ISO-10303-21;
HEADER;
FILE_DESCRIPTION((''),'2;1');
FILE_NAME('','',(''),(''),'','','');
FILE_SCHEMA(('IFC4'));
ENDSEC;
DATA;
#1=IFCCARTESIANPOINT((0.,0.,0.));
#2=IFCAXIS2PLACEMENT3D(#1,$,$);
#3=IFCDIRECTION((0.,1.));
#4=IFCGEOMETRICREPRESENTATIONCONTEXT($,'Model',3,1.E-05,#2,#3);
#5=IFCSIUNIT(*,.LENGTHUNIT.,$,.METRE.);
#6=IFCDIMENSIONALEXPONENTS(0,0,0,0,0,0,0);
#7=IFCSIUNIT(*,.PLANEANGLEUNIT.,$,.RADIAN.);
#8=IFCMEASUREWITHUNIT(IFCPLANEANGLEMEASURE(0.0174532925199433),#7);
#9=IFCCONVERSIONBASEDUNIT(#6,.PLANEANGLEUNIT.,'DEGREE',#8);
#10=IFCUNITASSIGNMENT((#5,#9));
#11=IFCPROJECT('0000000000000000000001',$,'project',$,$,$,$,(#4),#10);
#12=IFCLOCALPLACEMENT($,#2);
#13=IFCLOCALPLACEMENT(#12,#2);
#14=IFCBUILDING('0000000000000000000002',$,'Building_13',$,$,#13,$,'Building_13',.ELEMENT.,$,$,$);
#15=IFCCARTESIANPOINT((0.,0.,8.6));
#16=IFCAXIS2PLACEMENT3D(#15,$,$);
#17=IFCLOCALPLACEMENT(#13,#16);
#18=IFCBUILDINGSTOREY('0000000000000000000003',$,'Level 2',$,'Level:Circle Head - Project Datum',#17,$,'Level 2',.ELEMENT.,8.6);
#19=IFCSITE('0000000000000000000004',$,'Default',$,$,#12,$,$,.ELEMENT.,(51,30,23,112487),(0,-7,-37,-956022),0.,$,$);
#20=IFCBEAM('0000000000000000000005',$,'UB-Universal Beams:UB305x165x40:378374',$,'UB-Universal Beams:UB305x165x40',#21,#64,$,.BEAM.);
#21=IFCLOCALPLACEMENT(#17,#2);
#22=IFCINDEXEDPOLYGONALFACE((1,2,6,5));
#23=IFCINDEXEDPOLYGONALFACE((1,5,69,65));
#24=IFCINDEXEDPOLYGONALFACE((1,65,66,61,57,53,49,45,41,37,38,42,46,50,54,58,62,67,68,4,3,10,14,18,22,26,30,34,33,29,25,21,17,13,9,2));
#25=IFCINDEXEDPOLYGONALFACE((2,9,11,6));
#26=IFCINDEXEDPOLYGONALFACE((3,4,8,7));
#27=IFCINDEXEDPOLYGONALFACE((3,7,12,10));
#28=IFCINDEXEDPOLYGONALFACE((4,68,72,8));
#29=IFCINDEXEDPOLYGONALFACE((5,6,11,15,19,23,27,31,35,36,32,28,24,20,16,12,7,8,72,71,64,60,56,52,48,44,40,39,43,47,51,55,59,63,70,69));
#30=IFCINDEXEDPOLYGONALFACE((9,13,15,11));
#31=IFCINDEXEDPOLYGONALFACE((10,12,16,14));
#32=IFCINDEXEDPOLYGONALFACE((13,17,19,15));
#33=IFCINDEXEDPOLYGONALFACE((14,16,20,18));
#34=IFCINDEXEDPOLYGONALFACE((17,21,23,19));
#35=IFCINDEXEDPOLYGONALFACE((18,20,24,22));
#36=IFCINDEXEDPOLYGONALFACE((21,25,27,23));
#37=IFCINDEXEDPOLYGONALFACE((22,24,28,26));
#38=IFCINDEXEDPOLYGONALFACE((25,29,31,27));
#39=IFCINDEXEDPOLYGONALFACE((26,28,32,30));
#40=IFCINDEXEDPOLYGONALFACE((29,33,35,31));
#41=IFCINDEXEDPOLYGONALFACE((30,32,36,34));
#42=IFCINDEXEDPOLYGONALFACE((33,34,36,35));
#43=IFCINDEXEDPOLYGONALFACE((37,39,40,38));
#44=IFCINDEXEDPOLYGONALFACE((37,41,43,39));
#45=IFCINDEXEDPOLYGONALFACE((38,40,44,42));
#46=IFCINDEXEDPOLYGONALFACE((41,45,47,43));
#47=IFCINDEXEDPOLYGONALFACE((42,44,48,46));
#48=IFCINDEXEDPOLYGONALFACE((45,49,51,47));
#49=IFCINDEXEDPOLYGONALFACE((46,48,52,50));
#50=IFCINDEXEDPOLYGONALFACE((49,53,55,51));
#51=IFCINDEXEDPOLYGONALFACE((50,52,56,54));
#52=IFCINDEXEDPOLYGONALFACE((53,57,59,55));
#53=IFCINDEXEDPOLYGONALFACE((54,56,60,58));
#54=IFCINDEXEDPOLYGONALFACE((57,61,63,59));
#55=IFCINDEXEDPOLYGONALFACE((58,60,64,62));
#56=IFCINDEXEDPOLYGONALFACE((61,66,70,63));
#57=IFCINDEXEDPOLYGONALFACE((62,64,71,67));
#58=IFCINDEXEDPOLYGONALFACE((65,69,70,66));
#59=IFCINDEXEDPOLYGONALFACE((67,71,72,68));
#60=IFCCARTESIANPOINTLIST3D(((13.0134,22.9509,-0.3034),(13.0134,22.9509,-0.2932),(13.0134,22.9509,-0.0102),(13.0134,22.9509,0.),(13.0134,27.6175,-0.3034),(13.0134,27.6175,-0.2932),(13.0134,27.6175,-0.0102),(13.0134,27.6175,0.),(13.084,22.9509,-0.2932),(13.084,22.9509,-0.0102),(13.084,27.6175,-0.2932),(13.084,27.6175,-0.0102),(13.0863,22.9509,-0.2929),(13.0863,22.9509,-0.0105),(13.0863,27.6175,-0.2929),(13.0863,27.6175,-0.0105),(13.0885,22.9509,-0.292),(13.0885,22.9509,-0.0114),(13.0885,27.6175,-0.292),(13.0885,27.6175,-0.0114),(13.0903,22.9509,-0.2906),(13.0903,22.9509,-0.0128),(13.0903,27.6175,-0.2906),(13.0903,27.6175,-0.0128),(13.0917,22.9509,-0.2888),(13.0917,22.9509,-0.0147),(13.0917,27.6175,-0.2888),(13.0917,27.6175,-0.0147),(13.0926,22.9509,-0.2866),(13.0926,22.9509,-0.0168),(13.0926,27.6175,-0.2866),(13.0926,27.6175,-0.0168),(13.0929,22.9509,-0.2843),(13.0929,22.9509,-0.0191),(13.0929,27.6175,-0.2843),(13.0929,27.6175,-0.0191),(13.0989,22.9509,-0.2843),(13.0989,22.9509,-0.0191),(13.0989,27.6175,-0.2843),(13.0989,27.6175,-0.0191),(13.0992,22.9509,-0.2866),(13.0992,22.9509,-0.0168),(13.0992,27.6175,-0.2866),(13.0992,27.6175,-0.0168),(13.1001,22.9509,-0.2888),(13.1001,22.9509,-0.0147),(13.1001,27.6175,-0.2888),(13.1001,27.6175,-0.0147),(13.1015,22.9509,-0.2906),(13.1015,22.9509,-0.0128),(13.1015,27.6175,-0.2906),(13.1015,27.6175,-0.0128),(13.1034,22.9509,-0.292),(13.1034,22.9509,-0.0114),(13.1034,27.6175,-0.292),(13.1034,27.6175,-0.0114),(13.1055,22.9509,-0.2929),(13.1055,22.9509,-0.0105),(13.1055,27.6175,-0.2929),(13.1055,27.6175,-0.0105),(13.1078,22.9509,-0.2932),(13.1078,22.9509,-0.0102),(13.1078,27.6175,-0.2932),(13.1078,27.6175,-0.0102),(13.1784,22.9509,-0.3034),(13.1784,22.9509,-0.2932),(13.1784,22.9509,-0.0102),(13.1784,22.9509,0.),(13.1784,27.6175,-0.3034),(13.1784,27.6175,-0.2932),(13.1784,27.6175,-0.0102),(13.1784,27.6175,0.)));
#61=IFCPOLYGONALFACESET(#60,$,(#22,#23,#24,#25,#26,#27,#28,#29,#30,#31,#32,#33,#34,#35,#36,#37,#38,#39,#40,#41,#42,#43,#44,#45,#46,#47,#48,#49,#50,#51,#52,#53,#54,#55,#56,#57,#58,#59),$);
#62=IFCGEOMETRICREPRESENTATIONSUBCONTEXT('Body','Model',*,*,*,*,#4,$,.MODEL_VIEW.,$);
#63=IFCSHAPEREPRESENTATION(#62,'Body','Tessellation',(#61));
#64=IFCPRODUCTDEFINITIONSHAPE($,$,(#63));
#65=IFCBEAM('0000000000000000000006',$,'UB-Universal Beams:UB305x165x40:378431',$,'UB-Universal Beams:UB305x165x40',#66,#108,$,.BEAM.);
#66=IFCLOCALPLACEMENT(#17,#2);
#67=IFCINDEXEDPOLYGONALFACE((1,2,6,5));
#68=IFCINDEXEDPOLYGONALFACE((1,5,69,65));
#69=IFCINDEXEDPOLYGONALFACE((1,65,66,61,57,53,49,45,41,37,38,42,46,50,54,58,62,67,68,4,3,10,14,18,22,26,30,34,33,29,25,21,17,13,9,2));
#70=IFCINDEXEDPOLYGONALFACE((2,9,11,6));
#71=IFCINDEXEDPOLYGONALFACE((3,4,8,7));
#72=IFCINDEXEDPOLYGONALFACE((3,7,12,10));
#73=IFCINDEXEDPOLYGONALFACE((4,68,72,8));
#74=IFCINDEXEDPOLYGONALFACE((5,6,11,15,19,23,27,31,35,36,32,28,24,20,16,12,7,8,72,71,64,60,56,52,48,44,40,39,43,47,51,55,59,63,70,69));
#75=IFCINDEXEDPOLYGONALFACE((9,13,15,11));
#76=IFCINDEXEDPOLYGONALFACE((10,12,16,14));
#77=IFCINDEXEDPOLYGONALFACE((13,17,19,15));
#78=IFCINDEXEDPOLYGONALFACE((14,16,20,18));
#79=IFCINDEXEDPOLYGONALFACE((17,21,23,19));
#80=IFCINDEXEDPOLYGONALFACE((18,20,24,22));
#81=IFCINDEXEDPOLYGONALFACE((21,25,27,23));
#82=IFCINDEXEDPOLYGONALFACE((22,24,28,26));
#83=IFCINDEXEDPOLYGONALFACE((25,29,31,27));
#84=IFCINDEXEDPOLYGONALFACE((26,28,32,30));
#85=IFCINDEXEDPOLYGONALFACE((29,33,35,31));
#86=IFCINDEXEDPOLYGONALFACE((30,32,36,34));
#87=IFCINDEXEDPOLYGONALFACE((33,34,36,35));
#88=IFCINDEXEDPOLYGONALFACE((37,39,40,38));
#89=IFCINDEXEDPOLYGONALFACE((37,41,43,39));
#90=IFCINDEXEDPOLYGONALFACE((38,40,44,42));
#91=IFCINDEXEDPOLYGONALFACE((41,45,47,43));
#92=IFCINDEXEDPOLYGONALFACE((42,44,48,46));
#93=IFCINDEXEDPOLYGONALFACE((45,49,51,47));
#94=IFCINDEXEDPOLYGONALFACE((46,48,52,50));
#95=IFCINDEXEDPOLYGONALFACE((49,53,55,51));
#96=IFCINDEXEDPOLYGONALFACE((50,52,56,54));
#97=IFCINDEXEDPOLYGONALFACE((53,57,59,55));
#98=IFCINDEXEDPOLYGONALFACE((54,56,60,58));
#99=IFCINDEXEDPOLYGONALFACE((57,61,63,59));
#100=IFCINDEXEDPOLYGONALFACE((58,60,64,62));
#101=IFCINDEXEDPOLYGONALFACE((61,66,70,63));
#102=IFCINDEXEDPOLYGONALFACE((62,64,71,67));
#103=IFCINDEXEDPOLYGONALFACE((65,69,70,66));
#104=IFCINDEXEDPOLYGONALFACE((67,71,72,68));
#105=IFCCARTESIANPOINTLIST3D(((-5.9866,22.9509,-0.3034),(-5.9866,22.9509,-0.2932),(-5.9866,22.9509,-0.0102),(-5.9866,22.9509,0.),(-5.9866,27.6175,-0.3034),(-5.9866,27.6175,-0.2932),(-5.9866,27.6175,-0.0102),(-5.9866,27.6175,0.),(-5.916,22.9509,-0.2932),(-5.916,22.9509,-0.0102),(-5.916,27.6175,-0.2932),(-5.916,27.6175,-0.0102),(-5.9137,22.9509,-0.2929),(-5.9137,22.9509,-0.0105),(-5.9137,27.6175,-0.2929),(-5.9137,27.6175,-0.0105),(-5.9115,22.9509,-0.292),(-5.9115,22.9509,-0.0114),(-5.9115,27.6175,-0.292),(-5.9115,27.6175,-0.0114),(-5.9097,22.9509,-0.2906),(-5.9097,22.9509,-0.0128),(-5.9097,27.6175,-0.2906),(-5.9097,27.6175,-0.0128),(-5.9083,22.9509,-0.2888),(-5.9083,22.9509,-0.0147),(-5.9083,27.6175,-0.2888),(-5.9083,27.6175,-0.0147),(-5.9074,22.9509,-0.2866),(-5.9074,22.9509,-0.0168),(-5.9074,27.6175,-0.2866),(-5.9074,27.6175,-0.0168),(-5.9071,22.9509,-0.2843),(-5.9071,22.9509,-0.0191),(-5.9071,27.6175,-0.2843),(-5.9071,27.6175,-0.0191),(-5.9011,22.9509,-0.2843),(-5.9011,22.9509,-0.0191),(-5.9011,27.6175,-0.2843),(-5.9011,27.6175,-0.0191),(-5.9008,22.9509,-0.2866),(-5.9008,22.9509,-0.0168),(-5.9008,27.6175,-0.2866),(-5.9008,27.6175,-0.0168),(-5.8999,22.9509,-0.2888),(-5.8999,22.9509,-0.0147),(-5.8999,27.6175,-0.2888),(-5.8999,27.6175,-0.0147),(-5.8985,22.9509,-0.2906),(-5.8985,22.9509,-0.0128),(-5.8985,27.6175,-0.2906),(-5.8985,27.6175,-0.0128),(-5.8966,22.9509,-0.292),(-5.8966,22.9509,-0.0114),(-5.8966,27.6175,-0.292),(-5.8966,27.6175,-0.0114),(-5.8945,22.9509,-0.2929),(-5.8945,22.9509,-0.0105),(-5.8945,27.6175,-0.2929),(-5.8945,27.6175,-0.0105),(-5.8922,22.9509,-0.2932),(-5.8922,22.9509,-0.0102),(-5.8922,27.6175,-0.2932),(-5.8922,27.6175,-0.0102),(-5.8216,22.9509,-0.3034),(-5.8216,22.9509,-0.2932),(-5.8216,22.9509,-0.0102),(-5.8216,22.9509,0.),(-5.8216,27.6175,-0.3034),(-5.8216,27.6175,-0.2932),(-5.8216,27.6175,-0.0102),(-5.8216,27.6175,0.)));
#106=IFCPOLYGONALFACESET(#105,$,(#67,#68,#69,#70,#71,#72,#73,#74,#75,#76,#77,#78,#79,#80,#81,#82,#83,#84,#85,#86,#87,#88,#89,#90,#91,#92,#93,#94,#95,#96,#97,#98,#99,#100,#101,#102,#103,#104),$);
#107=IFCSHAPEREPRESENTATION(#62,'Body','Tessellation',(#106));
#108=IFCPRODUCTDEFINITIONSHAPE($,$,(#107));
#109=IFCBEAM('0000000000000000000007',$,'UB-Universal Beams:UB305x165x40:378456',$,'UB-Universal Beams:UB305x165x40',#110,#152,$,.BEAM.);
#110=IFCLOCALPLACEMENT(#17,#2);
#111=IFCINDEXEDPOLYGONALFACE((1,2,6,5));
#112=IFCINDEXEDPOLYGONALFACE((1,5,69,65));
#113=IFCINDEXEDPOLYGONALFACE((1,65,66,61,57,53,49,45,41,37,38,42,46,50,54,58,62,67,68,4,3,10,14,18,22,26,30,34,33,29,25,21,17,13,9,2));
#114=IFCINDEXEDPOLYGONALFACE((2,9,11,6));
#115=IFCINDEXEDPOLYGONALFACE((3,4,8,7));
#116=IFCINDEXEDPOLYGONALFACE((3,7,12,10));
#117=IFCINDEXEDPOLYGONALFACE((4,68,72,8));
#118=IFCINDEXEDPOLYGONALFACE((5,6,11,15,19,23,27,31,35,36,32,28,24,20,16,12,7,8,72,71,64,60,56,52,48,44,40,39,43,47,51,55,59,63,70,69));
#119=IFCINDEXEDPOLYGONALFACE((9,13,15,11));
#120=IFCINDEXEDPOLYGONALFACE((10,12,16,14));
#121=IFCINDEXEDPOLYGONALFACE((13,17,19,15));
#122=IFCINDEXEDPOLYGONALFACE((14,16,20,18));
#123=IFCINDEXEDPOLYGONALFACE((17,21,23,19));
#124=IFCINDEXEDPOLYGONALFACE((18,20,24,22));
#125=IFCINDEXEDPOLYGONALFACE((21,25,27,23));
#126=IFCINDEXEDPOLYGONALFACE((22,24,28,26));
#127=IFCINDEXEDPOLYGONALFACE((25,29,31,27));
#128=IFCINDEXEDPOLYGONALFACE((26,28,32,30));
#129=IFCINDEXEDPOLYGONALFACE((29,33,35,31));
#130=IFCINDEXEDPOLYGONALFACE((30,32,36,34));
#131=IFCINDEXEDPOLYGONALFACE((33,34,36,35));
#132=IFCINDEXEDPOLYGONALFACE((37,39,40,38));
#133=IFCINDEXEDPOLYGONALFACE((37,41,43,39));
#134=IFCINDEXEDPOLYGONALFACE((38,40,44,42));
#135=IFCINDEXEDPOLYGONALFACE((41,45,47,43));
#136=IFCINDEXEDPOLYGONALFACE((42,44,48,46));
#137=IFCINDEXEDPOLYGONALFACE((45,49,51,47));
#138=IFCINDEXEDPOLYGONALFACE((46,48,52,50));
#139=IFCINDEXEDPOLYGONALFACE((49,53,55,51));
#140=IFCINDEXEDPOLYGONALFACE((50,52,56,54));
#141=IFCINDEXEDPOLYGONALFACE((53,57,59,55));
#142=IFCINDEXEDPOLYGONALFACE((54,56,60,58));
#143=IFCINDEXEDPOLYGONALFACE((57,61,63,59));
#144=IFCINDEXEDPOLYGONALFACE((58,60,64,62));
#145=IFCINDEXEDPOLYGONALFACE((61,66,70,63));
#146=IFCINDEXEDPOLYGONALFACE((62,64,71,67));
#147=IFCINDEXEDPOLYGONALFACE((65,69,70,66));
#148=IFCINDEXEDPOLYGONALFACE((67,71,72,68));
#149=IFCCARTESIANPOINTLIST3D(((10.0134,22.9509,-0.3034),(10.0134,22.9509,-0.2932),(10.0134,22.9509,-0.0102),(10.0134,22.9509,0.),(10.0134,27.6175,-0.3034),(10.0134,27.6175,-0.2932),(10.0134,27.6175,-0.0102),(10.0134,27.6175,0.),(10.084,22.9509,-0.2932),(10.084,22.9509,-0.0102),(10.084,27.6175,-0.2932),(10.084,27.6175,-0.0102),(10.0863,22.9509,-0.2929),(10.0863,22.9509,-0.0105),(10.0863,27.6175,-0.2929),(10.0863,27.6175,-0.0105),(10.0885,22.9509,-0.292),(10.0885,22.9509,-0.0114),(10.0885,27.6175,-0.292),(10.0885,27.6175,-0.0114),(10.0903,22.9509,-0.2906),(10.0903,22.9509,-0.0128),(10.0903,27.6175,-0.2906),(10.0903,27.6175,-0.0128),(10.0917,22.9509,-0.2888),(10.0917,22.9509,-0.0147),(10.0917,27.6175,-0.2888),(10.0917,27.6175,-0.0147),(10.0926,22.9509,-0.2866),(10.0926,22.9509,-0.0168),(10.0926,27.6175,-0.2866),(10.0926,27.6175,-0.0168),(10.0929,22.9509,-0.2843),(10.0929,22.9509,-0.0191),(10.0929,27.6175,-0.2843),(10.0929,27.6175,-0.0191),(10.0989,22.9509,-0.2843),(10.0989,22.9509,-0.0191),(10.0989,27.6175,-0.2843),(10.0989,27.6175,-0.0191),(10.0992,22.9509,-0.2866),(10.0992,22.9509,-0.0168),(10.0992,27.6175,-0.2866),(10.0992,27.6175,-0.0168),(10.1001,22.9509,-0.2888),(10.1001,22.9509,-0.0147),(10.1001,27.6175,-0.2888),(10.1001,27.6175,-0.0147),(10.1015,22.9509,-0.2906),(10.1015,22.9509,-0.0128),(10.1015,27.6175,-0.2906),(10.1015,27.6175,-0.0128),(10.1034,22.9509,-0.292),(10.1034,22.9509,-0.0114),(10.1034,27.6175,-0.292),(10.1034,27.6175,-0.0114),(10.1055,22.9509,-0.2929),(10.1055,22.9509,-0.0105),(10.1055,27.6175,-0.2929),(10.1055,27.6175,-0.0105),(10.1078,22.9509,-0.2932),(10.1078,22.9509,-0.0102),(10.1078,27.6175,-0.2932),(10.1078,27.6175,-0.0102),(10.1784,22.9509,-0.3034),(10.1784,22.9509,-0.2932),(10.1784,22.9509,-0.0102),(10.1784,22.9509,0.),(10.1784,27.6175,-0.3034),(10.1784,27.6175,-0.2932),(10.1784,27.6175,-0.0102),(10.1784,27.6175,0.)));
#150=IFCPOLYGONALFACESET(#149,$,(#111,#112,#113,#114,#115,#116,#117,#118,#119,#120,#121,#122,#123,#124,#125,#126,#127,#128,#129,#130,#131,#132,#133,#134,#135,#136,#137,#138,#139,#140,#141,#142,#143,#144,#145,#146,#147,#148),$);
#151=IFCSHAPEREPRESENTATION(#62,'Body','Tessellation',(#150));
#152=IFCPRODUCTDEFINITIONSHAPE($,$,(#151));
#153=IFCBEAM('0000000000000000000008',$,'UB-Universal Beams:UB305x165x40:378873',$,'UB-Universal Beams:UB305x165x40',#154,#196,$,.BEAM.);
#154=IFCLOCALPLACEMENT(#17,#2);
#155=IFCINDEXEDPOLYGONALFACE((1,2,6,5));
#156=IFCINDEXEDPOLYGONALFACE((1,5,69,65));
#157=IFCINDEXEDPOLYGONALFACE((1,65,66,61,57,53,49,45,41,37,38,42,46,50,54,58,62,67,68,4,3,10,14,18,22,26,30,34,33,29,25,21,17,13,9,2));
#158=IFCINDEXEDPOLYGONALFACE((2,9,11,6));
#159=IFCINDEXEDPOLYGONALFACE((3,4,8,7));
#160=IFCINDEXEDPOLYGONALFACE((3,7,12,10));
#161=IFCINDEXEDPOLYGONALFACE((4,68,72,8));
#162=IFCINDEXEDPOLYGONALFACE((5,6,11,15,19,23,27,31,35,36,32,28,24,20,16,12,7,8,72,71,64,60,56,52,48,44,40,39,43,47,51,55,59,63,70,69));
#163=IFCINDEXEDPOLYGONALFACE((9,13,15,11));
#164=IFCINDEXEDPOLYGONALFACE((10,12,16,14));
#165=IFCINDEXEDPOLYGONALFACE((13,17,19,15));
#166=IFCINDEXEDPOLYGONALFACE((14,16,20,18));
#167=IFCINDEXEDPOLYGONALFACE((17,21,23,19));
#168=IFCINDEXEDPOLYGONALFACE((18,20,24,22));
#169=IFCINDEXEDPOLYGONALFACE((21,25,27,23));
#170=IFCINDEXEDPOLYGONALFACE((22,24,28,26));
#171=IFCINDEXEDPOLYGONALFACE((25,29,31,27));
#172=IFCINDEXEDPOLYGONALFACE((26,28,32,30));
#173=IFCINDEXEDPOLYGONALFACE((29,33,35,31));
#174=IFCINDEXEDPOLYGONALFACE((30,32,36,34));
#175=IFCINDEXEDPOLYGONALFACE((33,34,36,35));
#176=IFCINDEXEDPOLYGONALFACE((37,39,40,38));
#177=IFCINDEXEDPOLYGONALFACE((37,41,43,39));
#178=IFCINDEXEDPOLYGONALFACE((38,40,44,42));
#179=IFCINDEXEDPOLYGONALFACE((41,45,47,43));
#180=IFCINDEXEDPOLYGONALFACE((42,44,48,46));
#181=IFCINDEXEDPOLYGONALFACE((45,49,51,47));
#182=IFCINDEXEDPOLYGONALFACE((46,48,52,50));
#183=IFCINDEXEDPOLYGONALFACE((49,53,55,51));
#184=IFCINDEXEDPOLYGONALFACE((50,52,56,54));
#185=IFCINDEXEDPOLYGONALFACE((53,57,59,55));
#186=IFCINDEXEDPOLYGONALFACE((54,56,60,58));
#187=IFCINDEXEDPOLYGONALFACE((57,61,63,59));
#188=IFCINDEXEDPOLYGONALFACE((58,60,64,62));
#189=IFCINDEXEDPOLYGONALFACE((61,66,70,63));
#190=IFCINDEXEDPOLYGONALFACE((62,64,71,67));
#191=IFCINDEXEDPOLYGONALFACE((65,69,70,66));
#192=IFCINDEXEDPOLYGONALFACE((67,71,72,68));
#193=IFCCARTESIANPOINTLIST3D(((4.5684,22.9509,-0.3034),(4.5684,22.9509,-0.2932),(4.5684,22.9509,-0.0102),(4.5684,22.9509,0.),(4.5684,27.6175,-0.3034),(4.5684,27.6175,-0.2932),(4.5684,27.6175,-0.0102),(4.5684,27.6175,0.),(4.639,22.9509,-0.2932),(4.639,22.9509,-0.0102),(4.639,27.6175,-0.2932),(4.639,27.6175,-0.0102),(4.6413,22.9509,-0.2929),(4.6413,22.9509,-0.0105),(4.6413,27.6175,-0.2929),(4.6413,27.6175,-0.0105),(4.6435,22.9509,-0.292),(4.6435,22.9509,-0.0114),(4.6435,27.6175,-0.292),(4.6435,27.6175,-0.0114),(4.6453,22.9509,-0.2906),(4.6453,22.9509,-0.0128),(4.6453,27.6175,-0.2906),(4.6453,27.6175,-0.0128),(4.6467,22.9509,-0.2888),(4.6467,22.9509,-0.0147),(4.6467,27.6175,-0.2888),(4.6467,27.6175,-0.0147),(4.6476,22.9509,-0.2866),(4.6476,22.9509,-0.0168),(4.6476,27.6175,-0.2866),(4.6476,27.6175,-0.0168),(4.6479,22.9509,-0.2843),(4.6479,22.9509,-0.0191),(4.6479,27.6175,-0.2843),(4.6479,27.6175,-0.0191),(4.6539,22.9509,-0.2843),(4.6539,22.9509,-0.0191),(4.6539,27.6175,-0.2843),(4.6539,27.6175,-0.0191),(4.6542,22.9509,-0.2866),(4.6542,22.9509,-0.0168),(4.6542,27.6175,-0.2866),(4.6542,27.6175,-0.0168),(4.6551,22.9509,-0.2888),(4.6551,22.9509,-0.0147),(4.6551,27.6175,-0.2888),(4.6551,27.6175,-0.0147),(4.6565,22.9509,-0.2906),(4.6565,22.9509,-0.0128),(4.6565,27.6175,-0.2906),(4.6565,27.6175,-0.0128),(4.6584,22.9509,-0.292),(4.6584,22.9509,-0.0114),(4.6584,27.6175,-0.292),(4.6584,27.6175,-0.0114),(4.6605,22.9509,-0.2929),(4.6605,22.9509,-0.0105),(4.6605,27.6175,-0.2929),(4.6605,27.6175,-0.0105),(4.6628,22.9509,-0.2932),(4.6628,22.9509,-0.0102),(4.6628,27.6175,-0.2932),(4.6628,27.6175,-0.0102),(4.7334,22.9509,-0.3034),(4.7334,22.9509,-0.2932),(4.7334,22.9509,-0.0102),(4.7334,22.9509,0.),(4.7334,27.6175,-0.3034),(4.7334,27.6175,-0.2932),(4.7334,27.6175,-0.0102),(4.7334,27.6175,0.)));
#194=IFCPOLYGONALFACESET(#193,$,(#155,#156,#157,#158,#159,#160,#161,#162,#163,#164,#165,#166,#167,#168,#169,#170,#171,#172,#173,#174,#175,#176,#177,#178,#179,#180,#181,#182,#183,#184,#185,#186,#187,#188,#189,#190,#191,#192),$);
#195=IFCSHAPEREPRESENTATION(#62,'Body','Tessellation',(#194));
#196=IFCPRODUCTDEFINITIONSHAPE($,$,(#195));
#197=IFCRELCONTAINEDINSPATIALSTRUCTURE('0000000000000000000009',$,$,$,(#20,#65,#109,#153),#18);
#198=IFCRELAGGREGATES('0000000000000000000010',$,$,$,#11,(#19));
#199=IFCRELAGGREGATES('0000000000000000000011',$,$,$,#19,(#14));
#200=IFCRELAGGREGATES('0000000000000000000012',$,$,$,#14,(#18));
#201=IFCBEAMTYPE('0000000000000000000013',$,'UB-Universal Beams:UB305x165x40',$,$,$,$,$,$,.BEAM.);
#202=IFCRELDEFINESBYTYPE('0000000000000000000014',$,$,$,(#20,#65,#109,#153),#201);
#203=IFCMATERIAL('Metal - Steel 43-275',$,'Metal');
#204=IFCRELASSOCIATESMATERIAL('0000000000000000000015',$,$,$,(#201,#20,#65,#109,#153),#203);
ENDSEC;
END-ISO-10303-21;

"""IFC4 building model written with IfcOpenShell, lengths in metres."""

from ifc_helpers import new_model, entity, si_unit, converted_unit, direction, frame, origin, place, context, subcontext, project, spatial, line, arc, indexed_curve, outline, extrude, source, transform, mapped, material, type_object, type_shapes, element, save


model = new_model("IFC4")

# Units and contexts
model_context = context("Model", 3, precision=1e-05, world=origin(), true_north=direction((0.0, 1.0)))
body_context = subcontext(model_context, "Body", "Model", "MODEL_VIEW")
ifc_project = project(units=[si_unit("LENGTHUNIT", "METRE"), converted_unit("PLANEANGLEUNIT", "DEGREE", entity("IfcPlaneAngleMeasure", 0.0174532925199433), si_unit("PLANEANGLEUNIT", "RADIAN"), dimensions=[0, 0, 0, 0, 0, 0, 0])], contexts=[model_context])

# Site, building, storey
site_placement = place(None, origin())
site = spatial("IfcSite", under=ifc_project, at=site_placement, Name="Default", CompositionType="ELEMENT", RefLatitude=(51, 30, 23, 112487), RefLongitude=(0, -7, -37, -956022), RefElevation=0.0)
building_placement = place(site_placement, origin())
building = spatial("IfcBuilding", under=site, at=building_placement, Name="Building_13", LongName="Building_13", CompositionType="ELEMENT")
storey_placement = place(building_placement, frame((0.0, 0.0, 8.6)))
storey = spatial("IfcBuildingStorey", under=building, at=storey_placement, Name="Level 2", ObjectType="Level:Circle Head - Project Datum", LongName="Level 2", CompositionType="ELEMENT", Elevation=8.6)

# Beams
ifc_material_1 = material(Name="Metal - Steel 43-275", Category="Metal")
beam_type_1 = type_object("IfcBeamType", Name="UB-Universal Beams:UB305x165x40", PredefinedType="BEAM", material=ifc_material_1)
shared_shape_1 = source(origin(), body_context, "Body", "SweptSolid", [
    extrude(outline(indexed_curve([(-0.0825, -0.1415), (-0.0825, -0.1517), (0.0825, -0.1517), (0.0825, -0.1415), (0.0119, -0.1415), (0.0056, -0.1389), (0.003, -0.1326), (0.003, 0.1326), (0.0056, 0.1389), (0.0119, 0.1415), (0.0825, 0.1415), (0.0825, 0.1517), (-0.0825, 0.1517), (-0.0825, 0.1415), (-0.0119, 0.1415), (-0.0056, 0.1389), (-0.003, 0.1326), (-0.003, -0.1326), (-0.0056, -0.1389), (-0.0119, -0.1415)], segments=[line(1, 2, 3, 4, 5), arc(5, 6, 7), line(7, 8), arc(8, 9, 10), line(10, 11, 12, 13, 14, 15), arc(15, 16, 17), line(17, 18), arc(18, 19, 20), line(20, 1)], self_intersect=False)), frame((-2.3333, 0.0, 0.0), z_axis=(-1.0, 0.0, 0.0), x_axis=(0.0, -1.0, 0.0)), (0.0, 0.0, -1.0), 4.6666),
])
type_shapes(beam_type_1, [shared_shape_1])
for number, where, z_axis, x_axis, name in (
    (1, (13.0959, 25.2842, -0.1517), (0.0, 0.0, 1.0), (0.0, -1.0, 0.0), "UB-Universal Beams:UB305x165x40:378374"),
    (2, (-5.9041, 25.2842, -0.1517), (0.0, 0.0, 1.0), (0.0, -1.0, 0.0), "UB-Universal Beams:UB305x165x40:378431"),
    (3, (10.0959, 25.2842, -0.1517), (0.0, 0.0, 1.0), (0.0, -1.0, 0.0), "UB-Universal Beams:UB305x165x40:378456"),
    (4, (4.6509, 25.2842, -0.1517), (0.0, 0.0, 1.0), (0.0, -1.0, 0.0), "UB-Universal Beams:UB305x165x40:378873"),
):
    element("IfcBeam", number, at=place(storey_placement, frame(where, z_axis=z_axis, x_axis=x_axis)), inside=storey, type_object=beam_type_1, material=ifc_material_1, Name=name, ObjectType="UB-Universal Beams:UB305x165x40", PredefinedType="BEAM", context=body_context, shape_type="MappedRepresentation", body=[
        mapped(shared_shape_1, transform((0.0, 0.0, 0.0), scale=1.0)),
    ])

save(model, "model.ifc")
